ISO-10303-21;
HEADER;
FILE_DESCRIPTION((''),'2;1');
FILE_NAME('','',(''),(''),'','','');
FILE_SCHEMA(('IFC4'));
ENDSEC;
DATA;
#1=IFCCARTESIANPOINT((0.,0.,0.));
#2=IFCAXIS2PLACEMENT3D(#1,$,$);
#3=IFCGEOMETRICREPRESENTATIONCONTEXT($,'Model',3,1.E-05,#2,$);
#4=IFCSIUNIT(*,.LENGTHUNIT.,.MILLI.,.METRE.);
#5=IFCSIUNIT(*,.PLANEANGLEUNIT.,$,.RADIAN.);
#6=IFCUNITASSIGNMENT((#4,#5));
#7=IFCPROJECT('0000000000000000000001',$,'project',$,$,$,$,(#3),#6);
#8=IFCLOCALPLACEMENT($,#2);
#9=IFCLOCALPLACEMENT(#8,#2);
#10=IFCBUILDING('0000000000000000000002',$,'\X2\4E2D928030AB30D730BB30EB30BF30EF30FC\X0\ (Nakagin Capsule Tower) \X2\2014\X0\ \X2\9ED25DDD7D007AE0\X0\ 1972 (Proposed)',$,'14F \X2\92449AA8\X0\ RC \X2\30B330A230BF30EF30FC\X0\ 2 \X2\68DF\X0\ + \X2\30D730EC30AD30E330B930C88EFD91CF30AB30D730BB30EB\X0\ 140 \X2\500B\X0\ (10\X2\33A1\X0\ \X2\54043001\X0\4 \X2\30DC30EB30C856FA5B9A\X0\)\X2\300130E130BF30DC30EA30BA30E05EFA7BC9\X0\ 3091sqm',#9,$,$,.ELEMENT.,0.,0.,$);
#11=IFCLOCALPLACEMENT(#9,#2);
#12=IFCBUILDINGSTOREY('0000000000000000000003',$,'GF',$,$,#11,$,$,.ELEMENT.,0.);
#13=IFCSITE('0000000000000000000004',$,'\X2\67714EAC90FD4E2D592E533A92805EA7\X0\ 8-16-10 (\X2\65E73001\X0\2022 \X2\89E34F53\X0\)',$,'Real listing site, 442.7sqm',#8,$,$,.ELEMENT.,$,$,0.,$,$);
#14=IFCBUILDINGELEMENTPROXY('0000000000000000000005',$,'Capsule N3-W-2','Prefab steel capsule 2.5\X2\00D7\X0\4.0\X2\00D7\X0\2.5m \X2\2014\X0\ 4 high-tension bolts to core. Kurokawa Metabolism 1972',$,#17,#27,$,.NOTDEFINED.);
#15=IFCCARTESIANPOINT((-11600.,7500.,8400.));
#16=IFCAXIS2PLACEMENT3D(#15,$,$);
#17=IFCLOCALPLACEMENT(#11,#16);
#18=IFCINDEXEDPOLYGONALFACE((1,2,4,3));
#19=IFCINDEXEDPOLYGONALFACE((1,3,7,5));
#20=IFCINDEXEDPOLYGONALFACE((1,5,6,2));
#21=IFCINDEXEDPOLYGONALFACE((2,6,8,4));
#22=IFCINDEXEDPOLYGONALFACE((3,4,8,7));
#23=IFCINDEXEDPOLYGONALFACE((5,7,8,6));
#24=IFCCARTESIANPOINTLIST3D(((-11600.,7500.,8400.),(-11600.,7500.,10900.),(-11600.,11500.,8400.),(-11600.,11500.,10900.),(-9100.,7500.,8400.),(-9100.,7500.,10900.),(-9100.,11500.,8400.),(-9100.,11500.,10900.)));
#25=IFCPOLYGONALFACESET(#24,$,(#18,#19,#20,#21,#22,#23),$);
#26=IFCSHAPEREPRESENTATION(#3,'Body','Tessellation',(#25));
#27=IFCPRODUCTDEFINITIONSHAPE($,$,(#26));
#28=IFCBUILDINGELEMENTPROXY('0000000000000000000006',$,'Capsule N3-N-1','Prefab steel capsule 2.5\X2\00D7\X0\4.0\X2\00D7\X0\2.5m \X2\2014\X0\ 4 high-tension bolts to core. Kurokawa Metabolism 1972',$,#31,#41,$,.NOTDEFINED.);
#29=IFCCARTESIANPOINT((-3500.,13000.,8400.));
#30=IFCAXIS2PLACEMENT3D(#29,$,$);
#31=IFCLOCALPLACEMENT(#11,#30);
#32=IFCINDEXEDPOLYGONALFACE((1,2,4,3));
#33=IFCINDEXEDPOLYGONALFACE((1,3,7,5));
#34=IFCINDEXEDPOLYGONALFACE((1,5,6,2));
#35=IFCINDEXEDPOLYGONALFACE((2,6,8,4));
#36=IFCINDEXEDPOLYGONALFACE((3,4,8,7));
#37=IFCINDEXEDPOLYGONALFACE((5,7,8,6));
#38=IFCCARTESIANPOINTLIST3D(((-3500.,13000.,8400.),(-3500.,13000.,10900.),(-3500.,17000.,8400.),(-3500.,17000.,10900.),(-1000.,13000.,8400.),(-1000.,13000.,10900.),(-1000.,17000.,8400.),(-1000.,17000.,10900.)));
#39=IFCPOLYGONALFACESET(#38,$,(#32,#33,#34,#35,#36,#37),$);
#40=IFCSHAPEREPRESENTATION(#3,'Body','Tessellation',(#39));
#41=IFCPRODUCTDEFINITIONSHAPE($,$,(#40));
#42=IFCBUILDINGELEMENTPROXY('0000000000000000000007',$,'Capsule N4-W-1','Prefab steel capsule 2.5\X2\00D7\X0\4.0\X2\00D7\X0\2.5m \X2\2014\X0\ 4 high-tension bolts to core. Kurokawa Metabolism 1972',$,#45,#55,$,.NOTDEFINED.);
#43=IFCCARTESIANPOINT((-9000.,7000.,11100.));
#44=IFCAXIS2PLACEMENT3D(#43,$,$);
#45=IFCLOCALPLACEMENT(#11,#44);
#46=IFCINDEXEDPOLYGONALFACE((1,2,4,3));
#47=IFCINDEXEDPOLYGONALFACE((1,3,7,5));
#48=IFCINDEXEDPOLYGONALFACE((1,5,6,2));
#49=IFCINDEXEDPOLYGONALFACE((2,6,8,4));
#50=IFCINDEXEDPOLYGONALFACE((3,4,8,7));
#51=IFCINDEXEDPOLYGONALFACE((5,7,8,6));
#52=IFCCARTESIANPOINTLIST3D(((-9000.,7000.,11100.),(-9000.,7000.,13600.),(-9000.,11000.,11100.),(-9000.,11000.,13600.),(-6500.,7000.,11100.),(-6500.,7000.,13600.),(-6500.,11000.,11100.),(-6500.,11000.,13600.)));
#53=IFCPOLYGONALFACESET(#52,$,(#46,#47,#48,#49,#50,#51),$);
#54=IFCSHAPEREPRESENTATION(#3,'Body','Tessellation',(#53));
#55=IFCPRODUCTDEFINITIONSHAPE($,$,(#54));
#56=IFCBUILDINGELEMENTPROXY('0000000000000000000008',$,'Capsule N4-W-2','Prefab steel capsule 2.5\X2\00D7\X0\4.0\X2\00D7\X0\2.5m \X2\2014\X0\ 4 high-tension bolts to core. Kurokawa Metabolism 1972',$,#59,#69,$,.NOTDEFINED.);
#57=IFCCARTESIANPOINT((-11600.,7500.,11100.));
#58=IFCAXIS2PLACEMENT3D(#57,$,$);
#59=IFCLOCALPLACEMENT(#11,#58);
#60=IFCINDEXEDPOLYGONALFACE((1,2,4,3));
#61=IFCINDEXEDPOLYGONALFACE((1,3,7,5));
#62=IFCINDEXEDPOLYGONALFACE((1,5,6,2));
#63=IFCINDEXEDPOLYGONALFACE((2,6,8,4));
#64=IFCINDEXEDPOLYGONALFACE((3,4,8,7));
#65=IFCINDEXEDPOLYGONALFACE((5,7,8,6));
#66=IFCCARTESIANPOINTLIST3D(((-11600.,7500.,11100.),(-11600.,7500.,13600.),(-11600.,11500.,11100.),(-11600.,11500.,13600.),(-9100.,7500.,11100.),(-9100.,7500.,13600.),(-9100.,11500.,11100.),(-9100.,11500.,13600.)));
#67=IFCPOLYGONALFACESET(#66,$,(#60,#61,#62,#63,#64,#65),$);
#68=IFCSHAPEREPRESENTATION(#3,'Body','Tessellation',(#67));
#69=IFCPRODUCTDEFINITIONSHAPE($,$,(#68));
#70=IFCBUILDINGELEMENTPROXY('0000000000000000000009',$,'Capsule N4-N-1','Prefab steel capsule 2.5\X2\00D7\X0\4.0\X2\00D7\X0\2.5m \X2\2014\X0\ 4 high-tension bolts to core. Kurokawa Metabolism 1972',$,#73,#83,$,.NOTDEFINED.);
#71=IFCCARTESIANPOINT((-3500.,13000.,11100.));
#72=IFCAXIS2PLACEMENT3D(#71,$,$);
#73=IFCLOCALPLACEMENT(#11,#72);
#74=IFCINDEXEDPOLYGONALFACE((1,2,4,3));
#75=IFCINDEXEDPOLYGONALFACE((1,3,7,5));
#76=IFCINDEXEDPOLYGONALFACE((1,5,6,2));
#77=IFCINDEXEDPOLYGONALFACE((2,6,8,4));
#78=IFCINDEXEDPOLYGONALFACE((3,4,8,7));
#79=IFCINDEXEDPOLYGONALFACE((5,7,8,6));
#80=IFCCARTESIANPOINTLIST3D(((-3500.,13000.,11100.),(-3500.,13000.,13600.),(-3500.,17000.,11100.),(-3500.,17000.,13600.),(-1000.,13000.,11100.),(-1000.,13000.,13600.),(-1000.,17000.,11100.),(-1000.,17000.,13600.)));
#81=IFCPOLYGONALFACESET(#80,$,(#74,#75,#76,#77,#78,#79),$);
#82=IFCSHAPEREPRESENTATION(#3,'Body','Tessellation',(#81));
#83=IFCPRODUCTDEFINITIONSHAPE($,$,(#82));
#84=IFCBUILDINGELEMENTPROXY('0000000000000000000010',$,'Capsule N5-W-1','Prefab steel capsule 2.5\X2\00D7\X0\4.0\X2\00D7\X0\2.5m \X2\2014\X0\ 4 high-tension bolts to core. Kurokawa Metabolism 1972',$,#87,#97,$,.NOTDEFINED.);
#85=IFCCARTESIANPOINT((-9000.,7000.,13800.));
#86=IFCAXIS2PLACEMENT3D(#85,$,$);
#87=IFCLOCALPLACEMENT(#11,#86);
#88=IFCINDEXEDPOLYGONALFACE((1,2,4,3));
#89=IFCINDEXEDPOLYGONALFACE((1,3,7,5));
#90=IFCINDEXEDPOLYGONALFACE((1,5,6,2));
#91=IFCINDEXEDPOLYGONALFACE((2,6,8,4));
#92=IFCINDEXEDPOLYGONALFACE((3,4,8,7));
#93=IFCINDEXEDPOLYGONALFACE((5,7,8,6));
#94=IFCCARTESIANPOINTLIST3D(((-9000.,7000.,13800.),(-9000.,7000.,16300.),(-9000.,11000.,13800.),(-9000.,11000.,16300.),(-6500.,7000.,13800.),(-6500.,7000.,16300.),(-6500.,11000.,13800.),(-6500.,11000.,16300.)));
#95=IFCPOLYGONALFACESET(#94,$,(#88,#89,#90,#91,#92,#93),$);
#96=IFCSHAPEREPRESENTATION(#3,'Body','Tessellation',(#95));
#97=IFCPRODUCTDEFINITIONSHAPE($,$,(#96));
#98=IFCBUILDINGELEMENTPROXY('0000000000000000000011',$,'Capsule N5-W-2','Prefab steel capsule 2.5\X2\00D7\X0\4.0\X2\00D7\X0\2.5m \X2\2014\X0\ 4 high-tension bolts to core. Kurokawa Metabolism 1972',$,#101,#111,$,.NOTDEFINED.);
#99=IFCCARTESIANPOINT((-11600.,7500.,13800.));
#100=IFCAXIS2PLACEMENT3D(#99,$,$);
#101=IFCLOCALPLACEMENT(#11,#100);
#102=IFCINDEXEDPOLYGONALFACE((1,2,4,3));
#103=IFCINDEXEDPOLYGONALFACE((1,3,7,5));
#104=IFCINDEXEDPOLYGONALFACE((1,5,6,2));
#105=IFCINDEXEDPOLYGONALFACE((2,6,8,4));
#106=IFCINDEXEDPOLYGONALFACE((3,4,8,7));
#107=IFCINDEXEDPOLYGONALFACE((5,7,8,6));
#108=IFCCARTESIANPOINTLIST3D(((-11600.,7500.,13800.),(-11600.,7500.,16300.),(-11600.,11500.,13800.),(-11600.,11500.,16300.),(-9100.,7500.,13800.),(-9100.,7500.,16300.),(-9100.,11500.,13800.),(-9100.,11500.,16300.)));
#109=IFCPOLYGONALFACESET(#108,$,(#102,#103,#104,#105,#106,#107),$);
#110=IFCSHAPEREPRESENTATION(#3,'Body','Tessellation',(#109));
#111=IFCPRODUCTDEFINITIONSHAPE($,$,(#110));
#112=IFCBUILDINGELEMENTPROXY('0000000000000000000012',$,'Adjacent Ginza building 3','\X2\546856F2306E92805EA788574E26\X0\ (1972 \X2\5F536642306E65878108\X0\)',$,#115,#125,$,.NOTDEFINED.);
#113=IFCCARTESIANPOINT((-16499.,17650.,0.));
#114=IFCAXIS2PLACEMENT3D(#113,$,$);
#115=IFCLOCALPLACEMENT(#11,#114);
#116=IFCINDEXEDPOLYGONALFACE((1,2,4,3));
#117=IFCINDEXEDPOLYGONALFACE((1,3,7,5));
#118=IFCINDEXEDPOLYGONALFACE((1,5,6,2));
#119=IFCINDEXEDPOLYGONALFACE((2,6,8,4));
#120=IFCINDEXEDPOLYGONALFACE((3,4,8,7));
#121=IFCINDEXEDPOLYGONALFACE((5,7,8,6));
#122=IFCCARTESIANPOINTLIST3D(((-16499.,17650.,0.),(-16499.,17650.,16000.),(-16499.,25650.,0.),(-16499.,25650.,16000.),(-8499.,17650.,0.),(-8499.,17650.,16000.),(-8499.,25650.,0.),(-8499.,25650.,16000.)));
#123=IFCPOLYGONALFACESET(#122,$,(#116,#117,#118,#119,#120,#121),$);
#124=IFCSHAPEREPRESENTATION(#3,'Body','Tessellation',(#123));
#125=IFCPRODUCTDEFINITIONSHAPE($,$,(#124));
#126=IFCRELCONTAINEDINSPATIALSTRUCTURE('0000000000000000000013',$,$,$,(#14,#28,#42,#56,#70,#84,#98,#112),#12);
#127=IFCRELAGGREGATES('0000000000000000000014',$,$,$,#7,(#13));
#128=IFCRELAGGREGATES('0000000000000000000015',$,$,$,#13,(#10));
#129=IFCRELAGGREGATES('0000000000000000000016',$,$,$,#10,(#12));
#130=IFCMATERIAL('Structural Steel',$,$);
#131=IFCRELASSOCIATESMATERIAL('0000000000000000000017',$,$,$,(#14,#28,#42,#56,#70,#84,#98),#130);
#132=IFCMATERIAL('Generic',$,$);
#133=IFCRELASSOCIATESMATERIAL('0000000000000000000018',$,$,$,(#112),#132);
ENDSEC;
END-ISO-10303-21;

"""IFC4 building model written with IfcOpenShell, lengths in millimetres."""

from ifc_helpers import new_model, si_unit, frame, frame_2d, origin, place, context, project, spatial, rectangle, extrude, material, element, save


model = new_model("IFC4")

# Units and contexts
model_context = context("Model", 3, precision=1e-05, world=origin())
ifc_project = project(units=[si_unit("LENGTHUNIT", "METRE", prefix="MILLI"), si_unit("PLANEANGLEUNIT", "RADIAN")], contexts=[model_context])

# Site, building, storey
site_placement = place(None, origin())
site = spatial("IfcSite", under=ifc_project, at=site_placement, Name="東京都中央区銀座 8-16-10 (旧、2022 解体)", ObjectType="Real listing site, 442.7sqm", CompositionType="ELEMENT", RefElevation=0.0)
building_placement = place(site_placement, origin())
building = spatial("IfcBuilding", under=site, at=building_placement, Name="中銀カプセルタワー (Nakagin Capsule Tower) — 黒川紀章 1972 (Proposed)", ObjectType="14F 鉄骨 RC コアタワー 2 棟 + プレキャスト軽量カプセル 140 個 (10㎡ 各、4 ボルト固定)、メタボリズム建築 3091sqm", CompositionType="ELEMENT", ElevationOfRefHeight=0.0, ElevationOfTerrain=0.0)
storey_placement = place(building_placement, origin())
storey = spatial("IfcBuildingStorey", under=building, at=storey_placement, Name="GF", CompositionType="ELEMENT", Elevation=0.0)

# Shared definitions
ifc_material_1 = material(Name="Structural Steel")

# Shared definitions
ifc_material_2 = material(Name="Generic")

# Building element proxies
proxy_1_placement = place(storey_placement, frame((-11600.0, 7500.0, 8400.0)))
element("IfcBuildingElementProxy", 1, at=proxy_1_placement, inside=storey, material=ifc_material_1, Name="Capsule N3-W-2", Description="Prefab steel capsule 2.5×4.0×2.5m — 4 high-tension bolts to core. Kurokawa Metabolism 1972", PredefinedType="NOTDEFINED", context=model_context, shape_type="SweptSolid", body=[
    extrude(rectangle(XDim=2500.0, YDim=4000.0, at=frame_2d((1250.0, 2000.0))), frame((-11600.0, 7500.0, 8400.0)), (0.0, 0.0, 1.0), 2500.0),
])
proxy_2_placement = place(storey_placement, frame((-3500.0, 13000.0, 8400.0)))
element("IfcBuildingElementProxy", 2, at=proxy_2_placement, inside=storey, material=ifc_material_1, Name="Capsule N3-N-1", Description="Prefab steel capsule 2.5×4.0×2.5m — 4 high-tension bolts to core. Kurokawa Metabolism 1972", PredefinedType="NOTDEFINED", context=model_context, shape_type="SweptSolid", body=[
    extrude(rectangle(XDim=2500.0, YDim=4000.0, at=frame_2d((1250.0, 2000.0))), frame((-3500.0, 13000.0, 8400.0)), (0.0, 0.0, 1.0), 2500.0),
])
proxy_3_placement = place(storey_placement, frame((-9000.0, 7000.0, 11100.0)))
element("IfcBuildingElementProxy", 3, at=proxy_3_placement, inside=storey, material=ifc_material_1, Name="Capsule N4-W-1", Description="Prefab steel capsule 2.5×4.0×2.5m — 4 high-tension bolts to core. Kurokawa Metabolism 1972", PredefinedType="NOTDEFINED", context=model_context, shape_type="SweptSolid", body=[
    extrude(rectangle(XDim=2500.0, YDim=4000.0, at=frame_2d((1250.0, 2000.0))), frame((-9000.0, 7000.0, 11100.0)), (0.0, 0.0, 1.0), 2500.0),
])
proxy_4_placement = place(storey_placement, frame((-11600.0, 7500.0, 11100.0)))
element("IfcBuildingElementProxy", 4, at=proxy_4_placement, inside=storey, material=ifc_material_1, Name="Capsule N4-W-2", Description="Prefab steel capsule 2.5×4.0×2.5m — 4 high-tension bolts to core. Kurokawa Metabolism 1972", PredefinedType="NOTDEFINED", context=model_context, shape_type="SweptSolid", body=[
    extrude(rectangle(XDim=2500.0, YDim=4000.0, at=frame_2d((1250.0, 2000.0))), frame((-11600.0, 7500.0, 11100.0)), (0.0, 0.0, 1.0), 2500.0),
])
proxy_5_placement = place(storey_placement, frame((-3500.0, 13000.0, 11100.0)))
element("IfcBuildingElementProxy", 5, at=proxy_5_placement, inside=storey, material=ifc_material_1, Name="Capsule N4-N-1", Description="Prefab steel capsule 2.5×4.0×2.5m — 4 high-tension bolts to core. Kurokawa Metabolism 1972", PredefinedType="NOTDEFINED", context=model_context, shape_type="SweptSolid", body=[
    extrude(rectangle(XDim=2500.0, YDim=4000.0, at=frame_2d((1250.0, 2000.0))), frame((-3500.0, 13000.0, 11100.0)), (0.0, 0.0, 1.0), 2500.0),
])
proxy_6_placement = place(storey_placement, frame((-9000.0, 7000.0, 13800.0)))
element("IfcBuildingElementProxy", 6, at=proxy_6_placement, inside=storey, material=ifc_material_1, Name="Capsule N5-W-1", Description="Prefab steel capsule 2.5×4.0×2.5m — 4 high-tension bolts to core. Kurokawa Metabolism 1972", PredefinedType="NOTDEFINED", context=model_context, shape_type="SweptSolid", body=[
    extrude(rectangle(XDim=2500.0, YDim=4000.0, at=frame_2d((1250.0, 2000.0))), frame((-9000.0, 7000.0, 13800.0)), (0.0, 0.0, 1.0), 2500.0),
])
proxy_7_placement = place(storey_placement, frame((-11600.0, 7500.0, 13800.0)))
element("IfcBuildingElementProxy", 7, at=proxy_7_placement, inside=storey, material=ifc_material_1, Name="Capsule N5-W-2", Description="Prefab steel capsule 2.5×4.0×2.5m — 4 high-tension bolts to core. Kurokawa Metabolism 1972", PredefinedType="NOTDEFINED", context=model_context, shape_type="SweptSolid", body=[
    extrude(rectangle(XDim=2500.0, YDim=4000.0, at=frame_2d((1250.0, 2000.0))), frame((-11600.0, 7500.0, 13800.0)), (0.0, 0.0, 1.0), 2500.0),
])
proxy_8_placement = place(storey_placement, frame((-16499.0, 17650.0, 0.0)))
element("IfcBuildingElementProxy", 8, at=proxy_8_placement, inside=storey, material=ifc_material_2, Name="Adjacent Ginza building 3", Description="周囲の銀座街並 (1972 当時の文脈)", PredefinedType="NOTDEFINED", context=model_context, shape_type="SweptSolid", body=[
    extrude(rectangle(XDim=8000.0, YDim=8000.0, at=frame_2d((4000.0, 4000.0))), frame((-16499.0, 17650.0, 0.0)), (0.0, 0.0, 1.0), 16000.0),
])

save(model, "model.ifc")
